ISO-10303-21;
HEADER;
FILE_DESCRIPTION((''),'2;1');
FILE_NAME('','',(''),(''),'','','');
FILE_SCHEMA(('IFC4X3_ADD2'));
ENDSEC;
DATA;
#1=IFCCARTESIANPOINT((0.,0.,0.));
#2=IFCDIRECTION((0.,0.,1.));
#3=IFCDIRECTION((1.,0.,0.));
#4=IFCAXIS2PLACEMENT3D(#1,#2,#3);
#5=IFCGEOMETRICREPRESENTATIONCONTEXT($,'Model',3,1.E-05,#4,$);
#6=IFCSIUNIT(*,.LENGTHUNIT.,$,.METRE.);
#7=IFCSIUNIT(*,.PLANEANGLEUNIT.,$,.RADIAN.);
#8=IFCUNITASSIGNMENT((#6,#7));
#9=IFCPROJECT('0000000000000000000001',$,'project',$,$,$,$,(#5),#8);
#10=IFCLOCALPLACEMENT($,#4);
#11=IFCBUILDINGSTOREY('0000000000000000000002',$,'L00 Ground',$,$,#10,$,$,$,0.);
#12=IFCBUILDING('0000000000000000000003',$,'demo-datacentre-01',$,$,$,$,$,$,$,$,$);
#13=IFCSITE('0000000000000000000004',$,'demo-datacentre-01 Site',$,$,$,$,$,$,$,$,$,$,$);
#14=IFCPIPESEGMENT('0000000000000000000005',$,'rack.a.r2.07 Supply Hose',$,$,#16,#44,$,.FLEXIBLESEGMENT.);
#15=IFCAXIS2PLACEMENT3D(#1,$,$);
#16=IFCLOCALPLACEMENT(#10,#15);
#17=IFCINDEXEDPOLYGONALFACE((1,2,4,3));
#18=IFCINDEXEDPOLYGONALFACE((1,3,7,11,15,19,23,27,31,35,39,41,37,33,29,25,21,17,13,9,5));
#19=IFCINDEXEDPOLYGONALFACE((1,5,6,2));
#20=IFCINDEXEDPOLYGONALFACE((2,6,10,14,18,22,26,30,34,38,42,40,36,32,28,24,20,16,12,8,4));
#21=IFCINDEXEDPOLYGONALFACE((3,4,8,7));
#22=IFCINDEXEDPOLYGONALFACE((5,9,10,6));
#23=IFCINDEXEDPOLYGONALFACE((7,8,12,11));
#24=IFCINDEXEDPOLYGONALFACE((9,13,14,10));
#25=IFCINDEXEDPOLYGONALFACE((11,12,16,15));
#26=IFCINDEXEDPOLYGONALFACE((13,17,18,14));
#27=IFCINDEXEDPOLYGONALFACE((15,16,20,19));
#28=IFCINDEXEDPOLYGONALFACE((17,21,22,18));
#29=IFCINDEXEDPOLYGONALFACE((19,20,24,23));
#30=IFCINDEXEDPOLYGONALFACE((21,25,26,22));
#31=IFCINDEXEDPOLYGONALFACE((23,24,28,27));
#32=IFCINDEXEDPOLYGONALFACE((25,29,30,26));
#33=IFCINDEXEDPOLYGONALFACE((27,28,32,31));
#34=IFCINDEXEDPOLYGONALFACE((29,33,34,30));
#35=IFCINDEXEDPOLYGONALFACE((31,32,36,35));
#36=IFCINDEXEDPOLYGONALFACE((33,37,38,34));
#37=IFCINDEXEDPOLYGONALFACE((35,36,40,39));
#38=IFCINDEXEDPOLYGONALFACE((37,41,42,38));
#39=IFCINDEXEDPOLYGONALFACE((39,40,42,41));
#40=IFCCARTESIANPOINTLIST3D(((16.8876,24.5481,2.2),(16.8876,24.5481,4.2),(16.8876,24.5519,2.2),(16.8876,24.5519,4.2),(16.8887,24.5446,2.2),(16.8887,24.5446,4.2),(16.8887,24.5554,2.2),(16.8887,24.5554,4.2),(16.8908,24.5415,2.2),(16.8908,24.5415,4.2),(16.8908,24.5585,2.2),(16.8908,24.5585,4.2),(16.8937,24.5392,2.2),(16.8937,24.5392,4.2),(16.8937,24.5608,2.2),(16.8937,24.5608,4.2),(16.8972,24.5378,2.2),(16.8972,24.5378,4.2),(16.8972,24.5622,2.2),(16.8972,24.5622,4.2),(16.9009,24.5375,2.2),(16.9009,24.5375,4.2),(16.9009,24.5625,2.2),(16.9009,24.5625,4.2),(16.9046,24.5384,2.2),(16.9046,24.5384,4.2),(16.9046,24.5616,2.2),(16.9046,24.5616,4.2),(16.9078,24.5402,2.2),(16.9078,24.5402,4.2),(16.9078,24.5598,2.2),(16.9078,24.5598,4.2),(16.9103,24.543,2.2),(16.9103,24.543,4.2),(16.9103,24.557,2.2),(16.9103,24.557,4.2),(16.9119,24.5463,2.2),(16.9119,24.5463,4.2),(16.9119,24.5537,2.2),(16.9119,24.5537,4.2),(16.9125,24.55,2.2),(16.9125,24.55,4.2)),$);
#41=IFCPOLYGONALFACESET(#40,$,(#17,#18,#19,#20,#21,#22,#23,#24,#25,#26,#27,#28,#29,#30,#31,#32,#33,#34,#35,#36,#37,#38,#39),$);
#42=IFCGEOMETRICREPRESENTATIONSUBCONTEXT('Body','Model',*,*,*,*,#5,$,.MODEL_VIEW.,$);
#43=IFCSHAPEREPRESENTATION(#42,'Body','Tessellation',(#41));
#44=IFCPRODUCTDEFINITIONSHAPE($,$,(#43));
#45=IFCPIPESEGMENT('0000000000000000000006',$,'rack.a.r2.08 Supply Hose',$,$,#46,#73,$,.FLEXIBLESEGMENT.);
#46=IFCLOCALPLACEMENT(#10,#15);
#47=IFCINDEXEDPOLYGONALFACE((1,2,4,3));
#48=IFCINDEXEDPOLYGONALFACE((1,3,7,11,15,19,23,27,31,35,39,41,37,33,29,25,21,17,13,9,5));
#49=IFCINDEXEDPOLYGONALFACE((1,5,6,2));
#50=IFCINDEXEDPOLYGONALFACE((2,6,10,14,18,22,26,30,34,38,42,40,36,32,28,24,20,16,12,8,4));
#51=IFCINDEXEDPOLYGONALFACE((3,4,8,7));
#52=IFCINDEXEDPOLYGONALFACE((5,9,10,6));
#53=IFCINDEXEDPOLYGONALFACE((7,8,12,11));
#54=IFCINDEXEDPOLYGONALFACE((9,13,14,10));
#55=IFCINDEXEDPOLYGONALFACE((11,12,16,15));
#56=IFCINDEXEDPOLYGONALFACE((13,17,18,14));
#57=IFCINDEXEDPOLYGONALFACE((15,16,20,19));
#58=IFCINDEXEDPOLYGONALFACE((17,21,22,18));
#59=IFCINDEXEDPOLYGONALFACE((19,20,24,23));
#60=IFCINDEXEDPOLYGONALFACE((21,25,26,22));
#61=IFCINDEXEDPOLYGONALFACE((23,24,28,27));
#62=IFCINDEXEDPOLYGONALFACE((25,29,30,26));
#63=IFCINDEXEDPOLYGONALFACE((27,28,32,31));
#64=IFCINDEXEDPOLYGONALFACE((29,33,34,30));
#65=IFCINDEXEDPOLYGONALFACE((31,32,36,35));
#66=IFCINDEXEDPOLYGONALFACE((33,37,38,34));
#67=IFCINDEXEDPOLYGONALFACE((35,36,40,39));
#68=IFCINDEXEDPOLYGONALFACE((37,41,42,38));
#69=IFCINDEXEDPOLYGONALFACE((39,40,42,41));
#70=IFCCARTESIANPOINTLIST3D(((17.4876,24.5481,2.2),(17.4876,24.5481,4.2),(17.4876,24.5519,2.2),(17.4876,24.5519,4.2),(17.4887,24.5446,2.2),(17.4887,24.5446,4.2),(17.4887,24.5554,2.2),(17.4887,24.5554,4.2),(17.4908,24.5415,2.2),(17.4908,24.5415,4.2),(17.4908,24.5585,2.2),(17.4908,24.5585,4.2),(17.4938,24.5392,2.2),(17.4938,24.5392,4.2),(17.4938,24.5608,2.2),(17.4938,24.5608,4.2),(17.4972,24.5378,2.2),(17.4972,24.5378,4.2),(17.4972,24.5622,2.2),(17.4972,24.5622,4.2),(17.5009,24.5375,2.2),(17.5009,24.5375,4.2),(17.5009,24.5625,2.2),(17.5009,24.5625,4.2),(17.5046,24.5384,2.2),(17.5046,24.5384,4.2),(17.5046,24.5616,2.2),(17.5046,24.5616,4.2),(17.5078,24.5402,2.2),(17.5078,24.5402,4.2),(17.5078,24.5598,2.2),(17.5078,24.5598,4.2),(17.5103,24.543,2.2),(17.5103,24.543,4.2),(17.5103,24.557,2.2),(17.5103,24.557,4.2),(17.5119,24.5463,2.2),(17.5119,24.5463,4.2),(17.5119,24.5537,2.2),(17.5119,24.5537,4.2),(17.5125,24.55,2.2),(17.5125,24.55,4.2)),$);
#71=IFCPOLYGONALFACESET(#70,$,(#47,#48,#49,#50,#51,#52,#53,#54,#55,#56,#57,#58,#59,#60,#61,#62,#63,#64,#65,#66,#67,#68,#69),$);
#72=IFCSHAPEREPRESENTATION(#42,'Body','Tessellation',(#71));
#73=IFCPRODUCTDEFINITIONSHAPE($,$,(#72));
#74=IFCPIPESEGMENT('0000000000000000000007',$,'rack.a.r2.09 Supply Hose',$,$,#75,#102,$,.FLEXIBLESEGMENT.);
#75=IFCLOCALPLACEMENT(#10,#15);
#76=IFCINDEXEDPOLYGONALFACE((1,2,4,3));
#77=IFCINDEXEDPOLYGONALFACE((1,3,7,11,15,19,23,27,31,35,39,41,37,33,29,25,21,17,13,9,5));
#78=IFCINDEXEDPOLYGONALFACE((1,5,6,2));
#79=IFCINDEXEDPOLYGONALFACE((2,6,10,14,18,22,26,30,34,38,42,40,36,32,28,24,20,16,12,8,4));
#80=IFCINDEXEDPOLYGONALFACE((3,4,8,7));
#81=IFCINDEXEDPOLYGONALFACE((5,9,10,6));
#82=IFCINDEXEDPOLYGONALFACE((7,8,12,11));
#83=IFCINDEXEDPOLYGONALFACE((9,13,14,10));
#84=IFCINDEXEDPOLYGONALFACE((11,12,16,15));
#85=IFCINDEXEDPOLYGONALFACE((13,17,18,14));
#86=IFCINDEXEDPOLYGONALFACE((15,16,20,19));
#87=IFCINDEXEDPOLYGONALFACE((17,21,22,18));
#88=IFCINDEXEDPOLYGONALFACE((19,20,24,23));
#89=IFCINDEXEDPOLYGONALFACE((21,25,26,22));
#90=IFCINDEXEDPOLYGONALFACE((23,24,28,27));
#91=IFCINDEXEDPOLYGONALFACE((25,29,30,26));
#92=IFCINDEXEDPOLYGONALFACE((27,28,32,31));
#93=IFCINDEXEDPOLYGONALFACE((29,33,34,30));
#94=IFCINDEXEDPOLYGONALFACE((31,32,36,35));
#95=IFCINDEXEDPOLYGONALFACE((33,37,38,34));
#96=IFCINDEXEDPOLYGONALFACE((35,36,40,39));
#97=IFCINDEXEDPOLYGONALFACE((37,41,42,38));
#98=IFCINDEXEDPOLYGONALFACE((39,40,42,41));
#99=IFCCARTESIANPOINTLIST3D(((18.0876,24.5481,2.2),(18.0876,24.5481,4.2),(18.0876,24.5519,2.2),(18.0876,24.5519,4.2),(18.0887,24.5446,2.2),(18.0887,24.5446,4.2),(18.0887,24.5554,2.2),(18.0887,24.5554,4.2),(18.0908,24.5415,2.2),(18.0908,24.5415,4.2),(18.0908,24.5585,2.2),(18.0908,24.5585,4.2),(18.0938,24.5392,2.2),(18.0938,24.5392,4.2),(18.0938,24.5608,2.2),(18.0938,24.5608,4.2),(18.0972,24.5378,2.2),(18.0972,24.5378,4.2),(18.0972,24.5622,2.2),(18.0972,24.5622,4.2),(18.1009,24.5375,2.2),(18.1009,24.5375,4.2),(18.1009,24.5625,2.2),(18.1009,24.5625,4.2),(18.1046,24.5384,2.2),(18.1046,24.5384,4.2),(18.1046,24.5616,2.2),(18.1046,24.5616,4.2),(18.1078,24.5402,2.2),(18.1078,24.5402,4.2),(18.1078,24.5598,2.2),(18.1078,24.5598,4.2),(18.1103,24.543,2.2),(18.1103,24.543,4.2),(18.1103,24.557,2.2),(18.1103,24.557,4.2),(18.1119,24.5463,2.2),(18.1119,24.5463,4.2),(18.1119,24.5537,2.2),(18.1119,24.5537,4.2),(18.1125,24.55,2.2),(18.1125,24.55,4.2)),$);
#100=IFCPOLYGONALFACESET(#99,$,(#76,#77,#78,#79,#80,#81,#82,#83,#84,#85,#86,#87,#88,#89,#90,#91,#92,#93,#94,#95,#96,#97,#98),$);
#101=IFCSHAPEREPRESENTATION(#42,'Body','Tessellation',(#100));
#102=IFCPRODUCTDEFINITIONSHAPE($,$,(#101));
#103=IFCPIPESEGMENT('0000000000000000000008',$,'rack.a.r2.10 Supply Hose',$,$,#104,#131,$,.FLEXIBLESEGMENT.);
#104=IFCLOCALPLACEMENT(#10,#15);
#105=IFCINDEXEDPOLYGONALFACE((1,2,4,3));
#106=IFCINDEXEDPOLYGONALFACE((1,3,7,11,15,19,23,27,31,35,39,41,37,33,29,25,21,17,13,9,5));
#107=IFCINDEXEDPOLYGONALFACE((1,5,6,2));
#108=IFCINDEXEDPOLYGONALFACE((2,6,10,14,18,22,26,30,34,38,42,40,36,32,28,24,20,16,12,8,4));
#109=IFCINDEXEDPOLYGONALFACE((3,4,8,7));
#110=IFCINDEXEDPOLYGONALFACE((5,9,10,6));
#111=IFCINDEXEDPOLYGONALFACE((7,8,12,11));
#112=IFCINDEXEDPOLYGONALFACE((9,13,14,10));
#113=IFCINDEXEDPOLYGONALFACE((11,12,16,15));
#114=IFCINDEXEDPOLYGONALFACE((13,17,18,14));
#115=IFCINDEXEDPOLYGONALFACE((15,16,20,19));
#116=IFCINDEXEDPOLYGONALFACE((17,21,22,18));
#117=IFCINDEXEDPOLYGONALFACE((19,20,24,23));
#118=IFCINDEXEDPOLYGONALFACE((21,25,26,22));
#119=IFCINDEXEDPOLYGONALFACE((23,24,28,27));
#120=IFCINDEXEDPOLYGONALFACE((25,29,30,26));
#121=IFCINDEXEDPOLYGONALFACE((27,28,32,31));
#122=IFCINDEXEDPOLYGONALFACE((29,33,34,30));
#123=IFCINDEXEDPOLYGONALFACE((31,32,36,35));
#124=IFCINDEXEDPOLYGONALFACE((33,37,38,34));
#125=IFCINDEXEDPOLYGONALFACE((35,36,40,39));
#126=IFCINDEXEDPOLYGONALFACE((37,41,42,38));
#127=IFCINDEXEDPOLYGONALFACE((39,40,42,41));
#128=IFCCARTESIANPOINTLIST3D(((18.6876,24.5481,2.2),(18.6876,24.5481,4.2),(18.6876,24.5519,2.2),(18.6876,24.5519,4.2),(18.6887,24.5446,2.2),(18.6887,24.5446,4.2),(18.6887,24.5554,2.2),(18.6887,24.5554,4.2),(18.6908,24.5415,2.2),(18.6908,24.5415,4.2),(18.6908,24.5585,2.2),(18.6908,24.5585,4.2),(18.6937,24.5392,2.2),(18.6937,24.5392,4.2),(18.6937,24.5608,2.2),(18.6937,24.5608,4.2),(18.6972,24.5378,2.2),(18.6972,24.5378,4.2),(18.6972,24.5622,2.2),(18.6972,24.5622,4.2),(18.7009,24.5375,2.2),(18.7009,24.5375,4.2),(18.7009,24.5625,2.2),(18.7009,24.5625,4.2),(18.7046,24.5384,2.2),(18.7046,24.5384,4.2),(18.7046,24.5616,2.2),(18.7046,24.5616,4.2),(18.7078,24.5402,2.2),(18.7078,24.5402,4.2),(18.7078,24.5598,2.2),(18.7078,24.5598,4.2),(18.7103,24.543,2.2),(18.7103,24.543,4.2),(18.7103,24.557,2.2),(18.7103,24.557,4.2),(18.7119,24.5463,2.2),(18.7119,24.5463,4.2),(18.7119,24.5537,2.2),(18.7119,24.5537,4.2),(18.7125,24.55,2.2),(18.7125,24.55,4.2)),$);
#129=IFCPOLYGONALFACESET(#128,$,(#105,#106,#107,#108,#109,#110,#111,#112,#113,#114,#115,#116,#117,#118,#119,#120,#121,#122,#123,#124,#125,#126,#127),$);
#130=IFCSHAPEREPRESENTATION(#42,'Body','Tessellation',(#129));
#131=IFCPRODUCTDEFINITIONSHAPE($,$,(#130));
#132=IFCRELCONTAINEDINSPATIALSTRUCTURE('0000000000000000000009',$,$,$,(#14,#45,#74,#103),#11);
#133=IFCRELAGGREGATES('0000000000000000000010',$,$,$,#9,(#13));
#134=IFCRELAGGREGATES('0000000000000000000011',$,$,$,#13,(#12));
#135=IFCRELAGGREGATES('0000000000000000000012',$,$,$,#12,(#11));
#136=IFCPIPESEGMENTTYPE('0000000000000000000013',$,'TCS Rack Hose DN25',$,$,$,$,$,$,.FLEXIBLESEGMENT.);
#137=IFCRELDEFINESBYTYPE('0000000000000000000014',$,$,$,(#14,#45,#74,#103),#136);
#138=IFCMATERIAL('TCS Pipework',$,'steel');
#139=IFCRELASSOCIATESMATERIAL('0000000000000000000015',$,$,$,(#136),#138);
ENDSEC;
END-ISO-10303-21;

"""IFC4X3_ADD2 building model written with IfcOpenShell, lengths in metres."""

from ifc_helpers import new_model, si_unit, frame, origin_with_axes, place, context, subcontext, project, spatial, circle, extrude, material, type_object, element, save


model = new_model("IFC4X3_ADD2")

# Units and contexts
model_context = context("Model", 3, precision=1e-05, world=origin_with_axes())
body_context = subcontext(model_context, "Body", "Model", "MODEL_VIEW")
ifc_project = project(units=[si_unit("LENGTHUNIT", "METRE"), si_unit("PLANEANGLEUNIT", "RADIAN")], contexts=[model_context])

# Site, building, storey
site = spatial("IfcSite", under=ifc_project, Name="demo-datacentre-01 Site")
building = spatial("IfcBuilding", under=site, Name="demo-datacentre-01")
storey_placement = place(None, origin_with_axes())
storey = spatial("IfcBuildingStorey", under=building, at=storey_placement, Name="L00 Ground", Elevation=0.0)

# Shared definitions
ifc_material = material(Name="TCS Pipework", Category="steel")

# Pipe segments
pipe_segment_type_1 = type_object("IfcPipeSegmentType", Name="TCS Rack Hose DN25", PredefinedType="FLEXIBLESEGMENT", material=ifc_material)
for number, where, z_axis, x_axis, name in (
    (1, (16.9, 24.55, 4.2), (0.0, 0.0, -1.0), (1.0, 0.0, 0.0), "rack.a.r2.07 Supply Hose"),
    (2, (17.5, 24.55, 4.2), (0.0, 0.0, -1.0), (1.0, 0.0, 0.0), "rack.a.r2.08 Supply Hose"),
    (3, (18.1, 24.55, 4.2), (0.0, 0.0, -1.0), (1.0, 0.0, 0.0), "rack.a.r2.09 Supply Hose"),
    (4, (18.7, 24.55, 4.2), (0.0, 0.0, -1.0), (1.0, 0.0, 0.0), "rack.a.r2.10 Supply Hose"),
):
    element("IfcPipeSegment", number, at=place(storey_placement, frame(where, z_axis=z_axis, x_axis=x_axis)), inside=storey, type_object=pipe_segment_type_1, Name=name, PredefinedType="FLEXIBLESEGMENT", context=body_context, shape_type="SweptSolid", body=[
        extrude(circle(Radius=0.0125), origin_with_axes(), (0.0, 0.0, 1.0), 2.0),
    ])

save(model, "model.ifc")
